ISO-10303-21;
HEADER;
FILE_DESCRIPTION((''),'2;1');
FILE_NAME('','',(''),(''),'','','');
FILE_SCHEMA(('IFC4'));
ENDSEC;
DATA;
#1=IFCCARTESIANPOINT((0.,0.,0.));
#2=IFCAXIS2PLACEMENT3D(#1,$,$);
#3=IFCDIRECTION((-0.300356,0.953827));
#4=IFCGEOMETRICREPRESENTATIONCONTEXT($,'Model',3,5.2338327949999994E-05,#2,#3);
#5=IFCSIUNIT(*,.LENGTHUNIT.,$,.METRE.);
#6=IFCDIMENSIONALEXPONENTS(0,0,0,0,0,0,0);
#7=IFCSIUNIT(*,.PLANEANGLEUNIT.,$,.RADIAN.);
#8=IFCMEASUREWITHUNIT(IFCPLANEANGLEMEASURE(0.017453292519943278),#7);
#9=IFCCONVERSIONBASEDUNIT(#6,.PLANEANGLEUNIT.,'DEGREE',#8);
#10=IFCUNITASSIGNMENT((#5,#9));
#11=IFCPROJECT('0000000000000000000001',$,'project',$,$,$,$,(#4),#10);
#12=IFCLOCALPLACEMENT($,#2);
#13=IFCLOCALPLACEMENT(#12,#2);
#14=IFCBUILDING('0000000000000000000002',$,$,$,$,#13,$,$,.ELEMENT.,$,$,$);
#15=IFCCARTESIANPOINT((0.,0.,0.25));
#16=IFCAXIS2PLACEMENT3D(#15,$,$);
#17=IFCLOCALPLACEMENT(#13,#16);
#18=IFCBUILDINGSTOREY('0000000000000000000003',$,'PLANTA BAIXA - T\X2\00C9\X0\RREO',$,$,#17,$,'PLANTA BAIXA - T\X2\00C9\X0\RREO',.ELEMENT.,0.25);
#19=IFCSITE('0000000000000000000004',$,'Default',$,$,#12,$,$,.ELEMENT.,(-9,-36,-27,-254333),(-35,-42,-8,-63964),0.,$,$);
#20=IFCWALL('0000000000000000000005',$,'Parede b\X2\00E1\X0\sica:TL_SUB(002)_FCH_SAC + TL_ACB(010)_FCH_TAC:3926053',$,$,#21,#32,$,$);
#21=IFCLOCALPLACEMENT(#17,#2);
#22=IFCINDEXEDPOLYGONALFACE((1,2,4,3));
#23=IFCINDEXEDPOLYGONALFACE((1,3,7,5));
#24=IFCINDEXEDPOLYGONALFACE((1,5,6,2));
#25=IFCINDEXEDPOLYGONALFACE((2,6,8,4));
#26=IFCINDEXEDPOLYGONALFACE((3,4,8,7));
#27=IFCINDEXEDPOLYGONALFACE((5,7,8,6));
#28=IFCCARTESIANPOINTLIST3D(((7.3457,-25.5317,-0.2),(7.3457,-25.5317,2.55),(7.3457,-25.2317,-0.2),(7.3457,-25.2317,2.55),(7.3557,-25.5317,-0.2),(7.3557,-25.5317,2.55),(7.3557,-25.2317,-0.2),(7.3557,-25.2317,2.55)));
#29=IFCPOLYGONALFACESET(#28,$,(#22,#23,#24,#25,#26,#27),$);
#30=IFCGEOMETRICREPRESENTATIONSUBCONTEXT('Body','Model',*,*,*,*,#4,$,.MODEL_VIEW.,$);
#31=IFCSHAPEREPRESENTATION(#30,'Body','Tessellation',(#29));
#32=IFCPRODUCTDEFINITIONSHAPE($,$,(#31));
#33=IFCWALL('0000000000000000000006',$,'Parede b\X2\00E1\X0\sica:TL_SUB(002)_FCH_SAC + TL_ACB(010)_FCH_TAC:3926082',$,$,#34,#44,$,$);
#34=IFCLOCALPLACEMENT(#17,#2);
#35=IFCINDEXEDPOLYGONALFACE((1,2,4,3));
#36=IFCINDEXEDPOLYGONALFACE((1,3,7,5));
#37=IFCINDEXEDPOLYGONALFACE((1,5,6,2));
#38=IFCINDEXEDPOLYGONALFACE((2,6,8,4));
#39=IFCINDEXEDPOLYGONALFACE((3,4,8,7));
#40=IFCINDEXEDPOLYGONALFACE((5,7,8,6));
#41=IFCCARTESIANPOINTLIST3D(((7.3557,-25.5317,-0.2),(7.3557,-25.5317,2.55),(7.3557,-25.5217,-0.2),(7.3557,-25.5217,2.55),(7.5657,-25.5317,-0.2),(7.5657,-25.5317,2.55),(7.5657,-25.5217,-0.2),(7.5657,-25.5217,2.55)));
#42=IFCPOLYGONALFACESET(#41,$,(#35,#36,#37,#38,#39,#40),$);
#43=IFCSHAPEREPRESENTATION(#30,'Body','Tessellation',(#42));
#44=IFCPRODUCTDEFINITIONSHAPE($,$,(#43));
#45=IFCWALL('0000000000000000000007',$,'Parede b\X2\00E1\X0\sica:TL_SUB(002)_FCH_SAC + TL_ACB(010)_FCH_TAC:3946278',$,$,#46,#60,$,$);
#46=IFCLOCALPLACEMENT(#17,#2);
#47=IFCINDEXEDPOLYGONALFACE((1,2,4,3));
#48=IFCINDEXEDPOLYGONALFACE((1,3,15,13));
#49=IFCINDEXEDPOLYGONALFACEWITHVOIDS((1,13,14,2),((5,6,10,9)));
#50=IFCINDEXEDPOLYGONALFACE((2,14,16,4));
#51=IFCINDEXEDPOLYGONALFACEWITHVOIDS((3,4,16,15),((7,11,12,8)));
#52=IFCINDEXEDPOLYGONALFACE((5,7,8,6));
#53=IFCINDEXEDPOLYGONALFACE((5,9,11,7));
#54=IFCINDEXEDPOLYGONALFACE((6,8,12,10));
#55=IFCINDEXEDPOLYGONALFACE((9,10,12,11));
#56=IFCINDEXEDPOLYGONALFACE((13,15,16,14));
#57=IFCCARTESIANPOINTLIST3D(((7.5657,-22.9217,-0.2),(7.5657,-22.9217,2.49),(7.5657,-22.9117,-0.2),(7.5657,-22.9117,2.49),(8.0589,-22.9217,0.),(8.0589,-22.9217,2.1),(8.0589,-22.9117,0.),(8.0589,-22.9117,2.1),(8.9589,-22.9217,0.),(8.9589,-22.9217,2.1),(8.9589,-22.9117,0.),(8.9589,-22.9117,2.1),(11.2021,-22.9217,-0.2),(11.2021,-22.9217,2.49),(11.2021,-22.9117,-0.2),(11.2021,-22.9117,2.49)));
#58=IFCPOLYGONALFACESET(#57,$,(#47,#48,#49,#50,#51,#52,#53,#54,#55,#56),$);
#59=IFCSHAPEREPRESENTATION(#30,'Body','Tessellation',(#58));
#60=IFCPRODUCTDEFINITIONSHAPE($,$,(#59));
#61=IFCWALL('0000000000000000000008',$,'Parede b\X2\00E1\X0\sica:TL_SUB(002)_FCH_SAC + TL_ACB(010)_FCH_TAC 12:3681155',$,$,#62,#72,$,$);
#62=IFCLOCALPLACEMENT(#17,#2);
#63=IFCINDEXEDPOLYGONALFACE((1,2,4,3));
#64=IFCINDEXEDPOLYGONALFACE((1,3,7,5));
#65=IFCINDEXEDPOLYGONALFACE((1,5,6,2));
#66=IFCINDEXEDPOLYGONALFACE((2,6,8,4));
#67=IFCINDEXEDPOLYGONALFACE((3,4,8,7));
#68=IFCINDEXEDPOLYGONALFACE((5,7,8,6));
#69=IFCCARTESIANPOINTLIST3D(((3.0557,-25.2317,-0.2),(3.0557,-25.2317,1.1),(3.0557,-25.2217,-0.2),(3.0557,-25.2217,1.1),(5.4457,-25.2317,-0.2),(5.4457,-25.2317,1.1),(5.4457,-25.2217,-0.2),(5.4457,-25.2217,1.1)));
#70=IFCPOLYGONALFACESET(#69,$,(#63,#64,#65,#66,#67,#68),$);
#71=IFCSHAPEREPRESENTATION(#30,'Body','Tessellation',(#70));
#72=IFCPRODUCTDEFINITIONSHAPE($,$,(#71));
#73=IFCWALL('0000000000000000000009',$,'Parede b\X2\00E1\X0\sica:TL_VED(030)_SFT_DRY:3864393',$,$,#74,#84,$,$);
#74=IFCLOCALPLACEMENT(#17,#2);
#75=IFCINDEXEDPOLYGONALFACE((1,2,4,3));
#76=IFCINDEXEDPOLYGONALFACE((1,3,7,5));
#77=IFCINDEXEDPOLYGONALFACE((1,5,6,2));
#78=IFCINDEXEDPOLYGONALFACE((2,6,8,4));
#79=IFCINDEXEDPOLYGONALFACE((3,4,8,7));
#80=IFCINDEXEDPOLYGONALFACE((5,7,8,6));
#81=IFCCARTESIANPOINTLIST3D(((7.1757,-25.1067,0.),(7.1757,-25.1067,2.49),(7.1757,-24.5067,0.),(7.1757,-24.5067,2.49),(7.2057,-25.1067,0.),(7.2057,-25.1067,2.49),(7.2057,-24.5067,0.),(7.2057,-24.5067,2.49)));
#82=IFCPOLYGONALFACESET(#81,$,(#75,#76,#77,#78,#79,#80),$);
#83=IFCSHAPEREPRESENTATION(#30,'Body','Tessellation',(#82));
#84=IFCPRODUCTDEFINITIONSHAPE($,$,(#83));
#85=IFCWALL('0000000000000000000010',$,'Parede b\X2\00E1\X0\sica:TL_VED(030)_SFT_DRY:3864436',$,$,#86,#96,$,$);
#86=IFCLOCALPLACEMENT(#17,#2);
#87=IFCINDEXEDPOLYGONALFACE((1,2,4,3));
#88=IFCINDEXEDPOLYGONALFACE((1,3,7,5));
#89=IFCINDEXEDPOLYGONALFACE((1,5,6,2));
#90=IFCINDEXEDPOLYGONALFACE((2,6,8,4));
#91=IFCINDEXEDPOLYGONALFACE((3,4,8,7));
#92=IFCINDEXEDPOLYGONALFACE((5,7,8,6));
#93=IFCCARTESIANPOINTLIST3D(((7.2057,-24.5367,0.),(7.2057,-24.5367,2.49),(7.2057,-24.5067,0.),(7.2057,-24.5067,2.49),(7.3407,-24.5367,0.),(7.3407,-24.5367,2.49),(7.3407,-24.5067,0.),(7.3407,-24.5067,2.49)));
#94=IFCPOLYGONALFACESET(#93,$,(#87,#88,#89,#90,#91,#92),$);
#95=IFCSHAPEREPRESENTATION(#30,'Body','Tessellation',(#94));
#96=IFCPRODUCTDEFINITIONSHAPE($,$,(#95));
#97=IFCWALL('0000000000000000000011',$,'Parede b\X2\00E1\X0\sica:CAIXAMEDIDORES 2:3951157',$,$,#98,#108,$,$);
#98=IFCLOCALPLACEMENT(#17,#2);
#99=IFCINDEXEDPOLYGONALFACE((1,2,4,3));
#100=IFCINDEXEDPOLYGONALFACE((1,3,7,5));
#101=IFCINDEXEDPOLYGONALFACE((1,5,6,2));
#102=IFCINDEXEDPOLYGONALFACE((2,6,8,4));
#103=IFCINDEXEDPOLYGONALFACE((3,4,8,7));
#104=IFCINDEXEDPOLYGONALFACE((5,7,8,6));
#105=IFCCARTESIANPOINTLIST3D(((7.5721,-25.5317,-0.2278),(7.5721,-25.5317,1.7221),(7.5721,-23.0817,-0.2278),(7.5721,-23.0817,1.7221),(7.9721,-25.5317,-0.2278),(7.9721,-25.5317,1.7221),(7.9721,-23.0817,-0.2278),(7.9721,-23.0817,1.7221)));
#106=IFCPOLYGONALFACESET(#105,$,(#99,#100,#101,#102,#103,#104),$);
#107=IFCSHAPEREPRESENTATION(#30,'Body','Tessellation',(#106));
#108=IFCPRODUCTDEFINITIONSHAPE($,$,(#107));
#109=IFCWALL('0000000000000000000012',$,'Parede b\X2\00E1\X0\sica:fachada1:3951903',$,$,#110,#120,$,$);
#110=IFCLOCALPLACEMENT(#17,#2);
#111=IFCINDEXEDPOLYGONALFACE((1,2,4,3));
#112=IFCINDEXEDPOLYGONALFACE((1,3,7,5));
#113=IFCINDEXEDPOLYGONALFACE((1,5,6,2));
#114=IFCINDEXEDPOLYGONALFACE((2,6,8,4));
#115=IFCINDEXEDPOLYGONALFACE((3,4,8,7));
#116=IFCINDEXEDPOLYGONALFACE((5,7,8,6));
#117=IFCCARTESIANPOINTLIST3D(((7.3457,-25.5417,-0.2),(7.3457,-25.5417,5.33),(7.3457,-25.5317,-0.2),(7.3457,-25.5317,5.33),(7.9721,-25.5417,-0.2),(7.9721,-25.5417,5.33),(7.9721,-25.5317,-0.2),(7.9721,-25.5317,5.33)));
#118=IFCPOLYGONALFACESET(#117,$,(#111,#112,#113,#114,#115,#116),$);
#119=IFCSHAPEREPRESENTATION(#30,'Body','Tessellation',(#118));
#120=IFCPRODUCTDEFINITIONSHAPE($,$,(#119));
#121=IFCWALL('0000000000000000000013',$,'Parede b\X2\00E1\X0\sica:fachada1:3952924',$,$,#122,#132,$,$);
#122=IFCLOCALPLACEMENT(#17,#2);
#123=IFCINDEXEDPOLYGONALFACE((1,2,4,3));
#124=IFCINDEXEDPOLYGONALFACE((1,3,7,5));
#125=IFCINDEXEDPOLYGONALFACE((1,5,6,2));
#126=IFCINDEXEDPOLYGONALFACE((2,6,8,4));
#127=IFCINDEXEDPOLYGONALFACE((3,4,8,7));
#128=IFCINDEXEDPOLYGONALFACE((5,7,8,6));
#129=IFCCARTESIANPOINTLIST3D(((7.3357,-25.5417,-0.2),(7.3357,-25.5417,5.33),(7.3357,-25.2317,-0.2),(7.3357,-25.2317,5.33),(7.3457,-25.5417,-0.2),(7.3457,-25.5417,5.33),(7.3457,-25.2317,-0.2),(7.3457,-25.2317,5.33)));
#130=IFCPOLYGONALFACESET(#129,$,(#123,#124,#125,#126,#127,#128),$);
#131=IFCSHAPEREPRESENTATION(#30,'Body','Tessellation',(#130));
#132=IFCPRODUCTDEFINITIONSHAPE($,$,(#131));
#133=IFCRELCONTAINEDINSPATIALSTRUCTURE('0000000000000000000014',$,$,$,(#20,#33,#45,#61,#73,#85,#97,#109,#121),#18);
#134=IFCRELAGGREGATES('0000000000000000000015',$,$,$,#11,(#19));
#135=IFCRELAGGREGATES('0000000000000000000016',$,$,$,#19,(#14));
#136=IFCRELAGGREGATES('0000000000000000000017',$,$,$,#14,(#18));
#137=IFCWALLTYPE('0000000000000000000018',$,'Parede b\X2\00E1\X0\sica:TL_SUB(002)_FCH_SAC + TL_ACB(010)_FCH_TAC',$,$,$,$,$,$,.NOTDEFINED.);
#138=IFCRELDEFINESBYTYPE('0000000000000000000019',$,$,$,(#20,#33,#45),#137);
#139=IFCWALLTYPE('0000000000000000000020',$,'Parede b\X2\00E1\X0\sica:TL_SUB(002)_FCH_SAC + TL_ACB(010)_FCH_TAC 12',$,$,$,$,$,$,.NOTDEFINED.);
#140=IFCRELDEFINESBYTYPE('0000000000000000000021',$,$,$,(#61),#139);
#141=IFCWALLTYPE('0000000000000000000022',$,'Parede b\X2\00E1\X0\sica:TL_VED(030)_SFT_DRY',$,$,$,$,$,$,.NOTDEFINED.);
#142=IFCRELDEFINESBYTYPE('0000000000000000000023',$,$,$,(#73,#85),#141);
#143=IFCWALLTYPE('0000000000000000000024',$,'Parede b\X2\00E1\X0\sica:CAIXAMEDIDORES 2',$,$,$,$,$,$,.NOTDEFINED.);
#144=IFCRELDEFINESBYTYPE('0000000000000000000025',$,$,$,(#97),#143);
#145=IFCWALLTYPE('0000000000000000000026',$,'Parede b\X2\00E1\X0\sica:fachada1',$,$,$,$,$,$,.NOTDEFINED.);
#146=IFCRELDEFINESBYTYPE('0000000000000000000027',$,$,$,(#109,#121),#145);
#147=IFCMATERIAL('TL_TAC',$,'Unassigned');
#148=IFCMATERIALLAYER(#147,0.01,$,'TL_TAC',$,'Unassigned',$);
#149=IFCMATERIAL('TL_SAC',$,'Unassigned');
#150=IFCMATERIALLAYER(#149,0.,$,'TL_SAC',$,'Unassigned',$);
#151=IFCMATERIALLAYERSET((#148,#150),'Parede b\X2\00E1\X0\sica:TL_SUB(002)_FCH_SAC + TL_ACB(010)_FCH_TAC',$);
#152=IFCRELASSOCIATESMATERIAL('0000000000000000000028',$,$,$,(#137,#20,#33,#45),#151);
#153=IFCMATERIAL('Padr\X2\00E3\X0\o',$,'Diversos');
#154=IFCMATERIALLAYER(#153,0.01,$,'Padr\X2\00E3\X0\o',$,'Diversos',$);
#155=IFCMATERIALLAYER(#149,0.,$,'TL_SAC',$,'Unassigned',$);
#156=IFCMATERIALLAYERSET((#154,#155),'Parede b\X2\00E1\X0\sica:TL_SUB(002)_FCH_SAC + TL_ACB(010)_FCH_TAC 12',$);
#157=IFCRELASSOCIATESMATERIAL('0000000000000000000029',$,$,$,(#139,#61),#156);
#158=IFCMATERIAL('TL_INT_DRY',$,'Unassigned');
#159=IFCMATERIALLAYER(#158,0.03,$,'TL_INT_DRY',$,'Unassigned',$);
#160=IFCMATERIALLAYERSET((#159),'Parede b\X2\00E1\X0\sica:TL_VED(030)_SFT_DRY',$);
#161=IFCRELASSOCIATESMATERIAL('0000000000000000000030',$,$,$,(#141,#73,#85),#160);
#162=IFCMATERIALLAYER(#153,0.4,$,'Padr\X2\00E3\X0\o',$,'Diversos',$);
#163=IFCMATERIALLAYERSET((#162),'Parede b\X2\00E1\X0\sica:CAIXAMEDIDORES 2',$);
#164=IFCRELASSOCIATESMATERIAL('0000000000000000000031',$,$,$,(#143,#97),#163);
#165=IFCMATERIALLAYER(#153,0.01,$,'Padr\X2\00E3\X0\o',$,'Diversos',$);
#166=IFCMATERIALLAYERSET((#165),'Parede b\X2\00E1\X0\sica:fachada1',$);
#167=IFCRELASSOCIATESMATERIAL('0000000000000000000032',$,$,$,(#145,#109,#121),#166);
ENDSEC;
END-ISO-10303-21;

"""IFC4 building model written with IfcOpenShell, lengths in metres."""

from ifc_helpers import new_model, entity, si_unit, converted_unit, direction, frame, frame_2d, origin, place, context, subcontext, project, spatial, polyline, rectangle, extrude, clip, bounded_halfspace, material, layer, layer_set, layer_usage, type_object, element, save


model = new_model("IFC4")

# Units and contexts
model_context = context("Model", 3, precision=5.2338327949999994e-05, world=origin(), true_north=direction((-0.300356, 0.953827)))
body_context = subcontext(model_context, "Body", "Model", "MODEL_VIEW")
ifc_project = project(units=[si_unit("LENGTHUNIT", "METRE"), converted_unit("PLANEANGLEUNIT", "DEGREE", entity("IfcPlaneAngleMeasure", 0.017453292519943278), si_unit("PLANEANGLEUNIT", "RADIAN"), dimensions=[0, 0, 0, 0, 0, 0, 0])], contexts=[model_context])

# Site, building, storey
site_placement = place(None, origin())
site = spatial("IfcSite", under=ifc_project, at=site_placement, Name="Default", CompositionType="ELEMENT", RefLatitude=(-9, -36, -27, -254333), RefLongitude=(-35, -42, -8, -63964), RefElevation=0.0)
building_placement = place(site_placement, origin())
building = spatial("IfcBuilding", under=site, at=building_placement, CompositionType="ELEMENT")
storey_placement = place(building_placement, frame((0.0, 0.0, 0.25)))
storey = spatial("IfcBuildingStorey", under=building, at=storey_placement, Name="PLANTA BAIXA - TÉRREO", LongName="PLANTA BAIXA - TÉRREO", CompositionType="ELEMENT", Elevation=0.25)

# Shared definitions
ifc_material_1 = material(Name="TL_SAC", Category="Unassigned")

# Shared definitions
ifc_material_2 = material(Name="TL_TAC", Category="Unassigned")
ifc_layer_1 = layer(ifc_material_2, 0.01, Name="TL_TAC", Category="Unassigned")
ifc_layer_2 = layer(ifc_material_1, 0.0, Name="TL_SAC", Category="Unassigned")
ifc_layer_set_1 = layer_set([ifc_layer_1, ifc_layer_2], Name="Parede básica:TL_SUB(002)_FCH_SAC + TL_ACB(010)_FCH_TAC")
wall_type_1 = type_object("IfcWallType", Name="Parede básica:TL_SUB(002)_FCH_SAC + TL_ACB(010)_FCH_TAC", PredefinedType="NOTDEFINED", material=ifc_layer_set_1)

# Walls
ifc_layer_usage_1 = layer_usage(ifc_layer_set_1, "AXIS2", "NEGATIVE", 0.005)
wall_1_placement = place(storey_placement, frame((7.3507, -25.2317, -0.2), z_axis=(0.0, 0.0, 1.0), x_axis=(0.0, -1.0, 0.0)))
element("IfcWall", 1, at=wall_1_placement, inside=storey, type_object=wall_type_1, material=ifc_layer_usage_1, Name="Parede básica:TL_SUB(002)_FCH_SAC + TL_ACB(010)_FCH_TAC:3926053", context=body_context, shape_type="SweptSolid", body=[
    extrude(rectangle(XDim=0.3, YDim=0.01, at=frame_2d((0.15, 0.0), x_axis=(-1.0, 0.0))), origin(), (0.0, 0.0, 1.0), 2.75),
])
ifc_layer_usage_2 = layer_usage(ifc_layer_set_1, "AXIS2", "NEGATIVE", 0.005)
wall_2_placement = place(storey_placement, frame((7.3557, -25.5267, -0.2)))
element("IfcWall", 2, at=wall_2_placement, inside=storey, type_object=wall_type_1, material=ifc_layer_usage_2, Name="Parede básica:TL_SUB(002)_FCH_SAC + TL_ACB(010)_FCH_TAC:3926082", context=body_context, shape_type="SweptSolid", body=[
    extrude(rectangle(XDim=0.21, YDim=0.01, at=frame_2d((0.105, 0.0), x_axis=(-1.0, 0.0))), origin(), (0.0, 0.0, 1.0), 2.75),
])

# Wall, opening
ifc_layer_usage_3 = layer_usage(ifc_layer_set_1, "AXIS2", "POSITIVE", -0.005)
wall_3_placement = place(storey_placement, frame((7.5657, -22.9167, -0.2)))
wall_3 = element("IfcWall", 3, at=wall_3_placement, inside=storey, type_object=wall_type_1, material=ifc_layer_usage_3, Name="Parede básica:TL_SUB(002)_FCH_SAC + TL_ACB(010)_FCH_TAC:3946278", context=body_context, shape_type="Clipping", body=[
    clip(extrude(rectangle(XDim=3.6364, YDim=0.01, at=frame_2d((1.8182, 0.0), x_axis=(-1.0, 0.0))), origin(), (0.0, 0.0, 1.0), 2.69), bounded_halfspace(frame((0.0, -0.005, 2.69), z_axis=(0.0, 0.0, -1.0), x_axis=(0.0, -1.0, 0.0)), True, frame((0.0, -0.005, 2.69)), polyline([(0.0, 0.0), (3.6364, 0.0), (3.6364, 0.01), (0.0, 0.01), (0.0, 0.0)]))),
])
opening_1_placement = place(wall_3_placement, frame((-7.5657, 22.9167, 0.2)))
element("IfcOpeningElement", 4, at=opening_1_placement, cuts=wall_3, PredefinedType="OPENING", context=body_context, shape_type="SweptSolid", body=[
    extrude(rectangle(XDim=2.1, YDim=0.9, at=frame_2d((0.0, 0.0), x_axis=(1.0, 0.0))), frame((8.5089, -24.5957, 1.05), z_axis=(0.0, 1.0, 0.0), x_axis=(0.0, 0.0, 1.0)), (0.0, 0.0, 1.0), 3.048),
])

# Walls
ifc_material_3 = material(Name="Padrão", Category="Diversos")
ifc_layer_3 = layer(ifc_material_3, 0.01, Name="Padrão", Category="Diversos")
ifc_layer_4 = layer(ifc_material_1, 0.0, Name="TL_SAC", Category="Unassigned")
ifc_layer_set_2 = layer_set([ifc_layer_3, ifc_layer_4], Name="Parede básica:TL_SUB(002)_FCH_SAC + TL_ACB(010)_FCH_TAC 12")
ifc_layer_usage_4 = layer_usage(ifc_layer_set_2, "AXIS2", "POSITIVE", -0.005)
wall_type_2 = type_object("IfcWallType", Name="Parede básica:TL_SUB(002)_FCH_SAC + TL_ACB(010)_FCH_TAC 12", PredefinedType="NOTDEFINED", material=ifc_layer_set_2)
wall_4_placement = place(storey_placement, frame((5.4457, -25.2267, -0.2), z_axis=(0.0, 0.0, 1.0), x_axis=(-1.0, 0.0, 0.0)))
element("IfcWall", 5, at=wall_4_placement, inside=storey, type_object=wall_type_2, material=ifc_layer_usage_4, Name="Parede básica:TL_SUB(002)_FCH_SAC + TL_ACB(010)_FCH_TAC 12:3681155", context=body_context, shape_type="SweptSolid", body=[
    extrude(rectangle(XDim=2.39, YDim=0.01, at=frame_2d((1.195, 0.0), x_axis=(-1.0, 0.0))), origin(), (0.0, 0.0, 1.0), 1.3),
])
ifc_material_4 = material(Name="TL_INT_DRY", Category="Unassigned")
ifc_layer_5 = layer(ifc_material_4, 0.03, Name="TL_INT_DRY", Category="Unassigned")
ifc_layer_set_3 = layer_set([ifc_layer_5], Name="Parede básica:TL_VED(030)_SFT_DRY")
ifc_layer_usage_5 = layer_usage(ifc_layer_set_3, "AXIS2", "NEGATIVE", 0.015)
wall_type_3 = type_object("IfcWallType", Name="Parede básica:TL_VED(030)_SFT_DRY", PredefinedType="NOTDEFINED", material=ifc_layer_set_3)
wall_5_placement = place(storey_placement, frame((7.1907, -25.1067, 0.0), z_axis=(0.0, 0.0, 1.0), x_axis=(0.0, 1.0, 0.0)))
element("IfcWall", 6, at=wall_5_placement, inside=storey, type_object=wall_type_3, material=ifc_layer_usage_5, Name="Parede básica:TL_VED(030)_SFT_DRY:3864393", context=body_context, shape_type="SweptSolid", body=[
    extrude(rectangle(XDim=0.6, YDim=0.03, at=frame_2d((0.3, 0.0), x_axis=(-1.0, 0.0))), origin(), (0.0, 0.0, 1.0), 2.49),
])
ifc_layer_usage_6 = layer_usage(ifc_layer_set_3, "AXIS2", "NEGATIVE", 0.015)
wall_6_placement = place(storey_placement, frame((7.2057, -24.5217, 0.0)))
element("IfcWall", 7, at=wall_6_placement, inside=storey, type_object=wall_type_3, material=ifc_layer_usage_6, Name="Parede básica:TL_VED(030)_SFT_DRY:3864436", context=body_context, shape_type="SweptSolid", body=[
    extrude(rectangle(XDim=0.135, YDim=0.03, at=frame_2d((0.0675, 0.0), x_axis=(-1.0, 0.0))), origin(), (0.0, 0.0, 1.0), 2.49),
])
ifc_layer_6 = layer(ifc_material_3, 0.4, Name="Padrão", Category="Diversos")
ifc_layer_set_4 = layer_set([ifc_layer_6], Name="Parede básica:CAIXAMEDIDORES 2")
ifc_layer_usage_7 = layer_usage(ifc_layer_set_4, "AXIS2", "NEGATIVE", 0.2)
wall_type_4 = type_object("IfcWallType", Name="Parede básica:CAIXAMEDIDORES 2", PredefinedType="NOTDEFINED", material=ifc_layer_set_4)
wall_7_placement = place(storey_placement, frame((7.7721, -23.0817, -0.2278), z_axis=(0.0, 0.0, 1.0), x_axis=(0.0, -1.0, 0.0)))
element("IfcWall", 8, at=wall_7_placement, inside=storey, type_object=wall_type_4, material=ifc_layer_usage_7, Name="Parede básica:CAIXAMEDIDORES 2:3951157", context=body_context, shape_type="SweptSolid", body=[
    extrude(rectangle(XDim=2.45, YDim=0.4, at=frame_2d((1.225, 0.0), x_axis=(-1.0, 0.0))), origin(), (0.0, 0.0, 1.0), 1.9499),
])
ifc_layer_7 = layer(ifc_material_3, 0.01, Name="Padrão", Category="Diversos")
ifc_layer_set_5 = layer_set([ifc_layer_7], Name="Parede básica:fachada1")
ifc_layer_usage_8 = layer_usage(ifc_layer_set_5, "AXIS2", "NEGATIVE", 0.005)
wall_type_5 = type_object("IfcWallType", Name="Parede básica:fachada1", PredefinedType="NOTDEFINED", material=ifc_layer_set_5)
wall_8_placement = place(storey_placement, frame((7.3457, -25.5367, -0.2)))
element("IfcWall", 9, at=wall_8_placement, inside=storey, type_object=wall_type_5, material=ifc_layer_usage_8, Name="Parede básica:fachada1:3951903", context=body_context, shape_type="SweptSolid", body=[
    extrude(rectangle(XDim=0.6264, YDim=0.01, at=frame_2d((0.3132, 0.0), x_axis=(-1.0, 0.0))), origin(), (0.0, 0.0, 1.0), 5.53),
])
ifc_layer_usage_9 = layer_usage(ifc_layer_set_5, "AXIS2", "NEGATIVE", 0.005)
wall_9_placement = place(storey_placement, frame((7.3407, -25.2317, -0.2), z_axis=(0.0, 0.0, 1.0), x_axis=(0.0, -1.0, 0.0)))
element("IfcWall", 10, at=wall_9_placement, inside=storey, type_object=wall_type_5, material=ifc_layer_usage_9, Name="Parede básica:fachada1:3952924", context=body_context, shape_type="SweptSolid", body=[
    extrude(rectangle(XDim=0.31, YDim=0.01, at=frame_2d((0.155, 0.0), x_axis=(-1.0, 0.0))), origin(), (0.0, 0.0, 1.0), 5.53),
])

save(model, "model.ifc")
